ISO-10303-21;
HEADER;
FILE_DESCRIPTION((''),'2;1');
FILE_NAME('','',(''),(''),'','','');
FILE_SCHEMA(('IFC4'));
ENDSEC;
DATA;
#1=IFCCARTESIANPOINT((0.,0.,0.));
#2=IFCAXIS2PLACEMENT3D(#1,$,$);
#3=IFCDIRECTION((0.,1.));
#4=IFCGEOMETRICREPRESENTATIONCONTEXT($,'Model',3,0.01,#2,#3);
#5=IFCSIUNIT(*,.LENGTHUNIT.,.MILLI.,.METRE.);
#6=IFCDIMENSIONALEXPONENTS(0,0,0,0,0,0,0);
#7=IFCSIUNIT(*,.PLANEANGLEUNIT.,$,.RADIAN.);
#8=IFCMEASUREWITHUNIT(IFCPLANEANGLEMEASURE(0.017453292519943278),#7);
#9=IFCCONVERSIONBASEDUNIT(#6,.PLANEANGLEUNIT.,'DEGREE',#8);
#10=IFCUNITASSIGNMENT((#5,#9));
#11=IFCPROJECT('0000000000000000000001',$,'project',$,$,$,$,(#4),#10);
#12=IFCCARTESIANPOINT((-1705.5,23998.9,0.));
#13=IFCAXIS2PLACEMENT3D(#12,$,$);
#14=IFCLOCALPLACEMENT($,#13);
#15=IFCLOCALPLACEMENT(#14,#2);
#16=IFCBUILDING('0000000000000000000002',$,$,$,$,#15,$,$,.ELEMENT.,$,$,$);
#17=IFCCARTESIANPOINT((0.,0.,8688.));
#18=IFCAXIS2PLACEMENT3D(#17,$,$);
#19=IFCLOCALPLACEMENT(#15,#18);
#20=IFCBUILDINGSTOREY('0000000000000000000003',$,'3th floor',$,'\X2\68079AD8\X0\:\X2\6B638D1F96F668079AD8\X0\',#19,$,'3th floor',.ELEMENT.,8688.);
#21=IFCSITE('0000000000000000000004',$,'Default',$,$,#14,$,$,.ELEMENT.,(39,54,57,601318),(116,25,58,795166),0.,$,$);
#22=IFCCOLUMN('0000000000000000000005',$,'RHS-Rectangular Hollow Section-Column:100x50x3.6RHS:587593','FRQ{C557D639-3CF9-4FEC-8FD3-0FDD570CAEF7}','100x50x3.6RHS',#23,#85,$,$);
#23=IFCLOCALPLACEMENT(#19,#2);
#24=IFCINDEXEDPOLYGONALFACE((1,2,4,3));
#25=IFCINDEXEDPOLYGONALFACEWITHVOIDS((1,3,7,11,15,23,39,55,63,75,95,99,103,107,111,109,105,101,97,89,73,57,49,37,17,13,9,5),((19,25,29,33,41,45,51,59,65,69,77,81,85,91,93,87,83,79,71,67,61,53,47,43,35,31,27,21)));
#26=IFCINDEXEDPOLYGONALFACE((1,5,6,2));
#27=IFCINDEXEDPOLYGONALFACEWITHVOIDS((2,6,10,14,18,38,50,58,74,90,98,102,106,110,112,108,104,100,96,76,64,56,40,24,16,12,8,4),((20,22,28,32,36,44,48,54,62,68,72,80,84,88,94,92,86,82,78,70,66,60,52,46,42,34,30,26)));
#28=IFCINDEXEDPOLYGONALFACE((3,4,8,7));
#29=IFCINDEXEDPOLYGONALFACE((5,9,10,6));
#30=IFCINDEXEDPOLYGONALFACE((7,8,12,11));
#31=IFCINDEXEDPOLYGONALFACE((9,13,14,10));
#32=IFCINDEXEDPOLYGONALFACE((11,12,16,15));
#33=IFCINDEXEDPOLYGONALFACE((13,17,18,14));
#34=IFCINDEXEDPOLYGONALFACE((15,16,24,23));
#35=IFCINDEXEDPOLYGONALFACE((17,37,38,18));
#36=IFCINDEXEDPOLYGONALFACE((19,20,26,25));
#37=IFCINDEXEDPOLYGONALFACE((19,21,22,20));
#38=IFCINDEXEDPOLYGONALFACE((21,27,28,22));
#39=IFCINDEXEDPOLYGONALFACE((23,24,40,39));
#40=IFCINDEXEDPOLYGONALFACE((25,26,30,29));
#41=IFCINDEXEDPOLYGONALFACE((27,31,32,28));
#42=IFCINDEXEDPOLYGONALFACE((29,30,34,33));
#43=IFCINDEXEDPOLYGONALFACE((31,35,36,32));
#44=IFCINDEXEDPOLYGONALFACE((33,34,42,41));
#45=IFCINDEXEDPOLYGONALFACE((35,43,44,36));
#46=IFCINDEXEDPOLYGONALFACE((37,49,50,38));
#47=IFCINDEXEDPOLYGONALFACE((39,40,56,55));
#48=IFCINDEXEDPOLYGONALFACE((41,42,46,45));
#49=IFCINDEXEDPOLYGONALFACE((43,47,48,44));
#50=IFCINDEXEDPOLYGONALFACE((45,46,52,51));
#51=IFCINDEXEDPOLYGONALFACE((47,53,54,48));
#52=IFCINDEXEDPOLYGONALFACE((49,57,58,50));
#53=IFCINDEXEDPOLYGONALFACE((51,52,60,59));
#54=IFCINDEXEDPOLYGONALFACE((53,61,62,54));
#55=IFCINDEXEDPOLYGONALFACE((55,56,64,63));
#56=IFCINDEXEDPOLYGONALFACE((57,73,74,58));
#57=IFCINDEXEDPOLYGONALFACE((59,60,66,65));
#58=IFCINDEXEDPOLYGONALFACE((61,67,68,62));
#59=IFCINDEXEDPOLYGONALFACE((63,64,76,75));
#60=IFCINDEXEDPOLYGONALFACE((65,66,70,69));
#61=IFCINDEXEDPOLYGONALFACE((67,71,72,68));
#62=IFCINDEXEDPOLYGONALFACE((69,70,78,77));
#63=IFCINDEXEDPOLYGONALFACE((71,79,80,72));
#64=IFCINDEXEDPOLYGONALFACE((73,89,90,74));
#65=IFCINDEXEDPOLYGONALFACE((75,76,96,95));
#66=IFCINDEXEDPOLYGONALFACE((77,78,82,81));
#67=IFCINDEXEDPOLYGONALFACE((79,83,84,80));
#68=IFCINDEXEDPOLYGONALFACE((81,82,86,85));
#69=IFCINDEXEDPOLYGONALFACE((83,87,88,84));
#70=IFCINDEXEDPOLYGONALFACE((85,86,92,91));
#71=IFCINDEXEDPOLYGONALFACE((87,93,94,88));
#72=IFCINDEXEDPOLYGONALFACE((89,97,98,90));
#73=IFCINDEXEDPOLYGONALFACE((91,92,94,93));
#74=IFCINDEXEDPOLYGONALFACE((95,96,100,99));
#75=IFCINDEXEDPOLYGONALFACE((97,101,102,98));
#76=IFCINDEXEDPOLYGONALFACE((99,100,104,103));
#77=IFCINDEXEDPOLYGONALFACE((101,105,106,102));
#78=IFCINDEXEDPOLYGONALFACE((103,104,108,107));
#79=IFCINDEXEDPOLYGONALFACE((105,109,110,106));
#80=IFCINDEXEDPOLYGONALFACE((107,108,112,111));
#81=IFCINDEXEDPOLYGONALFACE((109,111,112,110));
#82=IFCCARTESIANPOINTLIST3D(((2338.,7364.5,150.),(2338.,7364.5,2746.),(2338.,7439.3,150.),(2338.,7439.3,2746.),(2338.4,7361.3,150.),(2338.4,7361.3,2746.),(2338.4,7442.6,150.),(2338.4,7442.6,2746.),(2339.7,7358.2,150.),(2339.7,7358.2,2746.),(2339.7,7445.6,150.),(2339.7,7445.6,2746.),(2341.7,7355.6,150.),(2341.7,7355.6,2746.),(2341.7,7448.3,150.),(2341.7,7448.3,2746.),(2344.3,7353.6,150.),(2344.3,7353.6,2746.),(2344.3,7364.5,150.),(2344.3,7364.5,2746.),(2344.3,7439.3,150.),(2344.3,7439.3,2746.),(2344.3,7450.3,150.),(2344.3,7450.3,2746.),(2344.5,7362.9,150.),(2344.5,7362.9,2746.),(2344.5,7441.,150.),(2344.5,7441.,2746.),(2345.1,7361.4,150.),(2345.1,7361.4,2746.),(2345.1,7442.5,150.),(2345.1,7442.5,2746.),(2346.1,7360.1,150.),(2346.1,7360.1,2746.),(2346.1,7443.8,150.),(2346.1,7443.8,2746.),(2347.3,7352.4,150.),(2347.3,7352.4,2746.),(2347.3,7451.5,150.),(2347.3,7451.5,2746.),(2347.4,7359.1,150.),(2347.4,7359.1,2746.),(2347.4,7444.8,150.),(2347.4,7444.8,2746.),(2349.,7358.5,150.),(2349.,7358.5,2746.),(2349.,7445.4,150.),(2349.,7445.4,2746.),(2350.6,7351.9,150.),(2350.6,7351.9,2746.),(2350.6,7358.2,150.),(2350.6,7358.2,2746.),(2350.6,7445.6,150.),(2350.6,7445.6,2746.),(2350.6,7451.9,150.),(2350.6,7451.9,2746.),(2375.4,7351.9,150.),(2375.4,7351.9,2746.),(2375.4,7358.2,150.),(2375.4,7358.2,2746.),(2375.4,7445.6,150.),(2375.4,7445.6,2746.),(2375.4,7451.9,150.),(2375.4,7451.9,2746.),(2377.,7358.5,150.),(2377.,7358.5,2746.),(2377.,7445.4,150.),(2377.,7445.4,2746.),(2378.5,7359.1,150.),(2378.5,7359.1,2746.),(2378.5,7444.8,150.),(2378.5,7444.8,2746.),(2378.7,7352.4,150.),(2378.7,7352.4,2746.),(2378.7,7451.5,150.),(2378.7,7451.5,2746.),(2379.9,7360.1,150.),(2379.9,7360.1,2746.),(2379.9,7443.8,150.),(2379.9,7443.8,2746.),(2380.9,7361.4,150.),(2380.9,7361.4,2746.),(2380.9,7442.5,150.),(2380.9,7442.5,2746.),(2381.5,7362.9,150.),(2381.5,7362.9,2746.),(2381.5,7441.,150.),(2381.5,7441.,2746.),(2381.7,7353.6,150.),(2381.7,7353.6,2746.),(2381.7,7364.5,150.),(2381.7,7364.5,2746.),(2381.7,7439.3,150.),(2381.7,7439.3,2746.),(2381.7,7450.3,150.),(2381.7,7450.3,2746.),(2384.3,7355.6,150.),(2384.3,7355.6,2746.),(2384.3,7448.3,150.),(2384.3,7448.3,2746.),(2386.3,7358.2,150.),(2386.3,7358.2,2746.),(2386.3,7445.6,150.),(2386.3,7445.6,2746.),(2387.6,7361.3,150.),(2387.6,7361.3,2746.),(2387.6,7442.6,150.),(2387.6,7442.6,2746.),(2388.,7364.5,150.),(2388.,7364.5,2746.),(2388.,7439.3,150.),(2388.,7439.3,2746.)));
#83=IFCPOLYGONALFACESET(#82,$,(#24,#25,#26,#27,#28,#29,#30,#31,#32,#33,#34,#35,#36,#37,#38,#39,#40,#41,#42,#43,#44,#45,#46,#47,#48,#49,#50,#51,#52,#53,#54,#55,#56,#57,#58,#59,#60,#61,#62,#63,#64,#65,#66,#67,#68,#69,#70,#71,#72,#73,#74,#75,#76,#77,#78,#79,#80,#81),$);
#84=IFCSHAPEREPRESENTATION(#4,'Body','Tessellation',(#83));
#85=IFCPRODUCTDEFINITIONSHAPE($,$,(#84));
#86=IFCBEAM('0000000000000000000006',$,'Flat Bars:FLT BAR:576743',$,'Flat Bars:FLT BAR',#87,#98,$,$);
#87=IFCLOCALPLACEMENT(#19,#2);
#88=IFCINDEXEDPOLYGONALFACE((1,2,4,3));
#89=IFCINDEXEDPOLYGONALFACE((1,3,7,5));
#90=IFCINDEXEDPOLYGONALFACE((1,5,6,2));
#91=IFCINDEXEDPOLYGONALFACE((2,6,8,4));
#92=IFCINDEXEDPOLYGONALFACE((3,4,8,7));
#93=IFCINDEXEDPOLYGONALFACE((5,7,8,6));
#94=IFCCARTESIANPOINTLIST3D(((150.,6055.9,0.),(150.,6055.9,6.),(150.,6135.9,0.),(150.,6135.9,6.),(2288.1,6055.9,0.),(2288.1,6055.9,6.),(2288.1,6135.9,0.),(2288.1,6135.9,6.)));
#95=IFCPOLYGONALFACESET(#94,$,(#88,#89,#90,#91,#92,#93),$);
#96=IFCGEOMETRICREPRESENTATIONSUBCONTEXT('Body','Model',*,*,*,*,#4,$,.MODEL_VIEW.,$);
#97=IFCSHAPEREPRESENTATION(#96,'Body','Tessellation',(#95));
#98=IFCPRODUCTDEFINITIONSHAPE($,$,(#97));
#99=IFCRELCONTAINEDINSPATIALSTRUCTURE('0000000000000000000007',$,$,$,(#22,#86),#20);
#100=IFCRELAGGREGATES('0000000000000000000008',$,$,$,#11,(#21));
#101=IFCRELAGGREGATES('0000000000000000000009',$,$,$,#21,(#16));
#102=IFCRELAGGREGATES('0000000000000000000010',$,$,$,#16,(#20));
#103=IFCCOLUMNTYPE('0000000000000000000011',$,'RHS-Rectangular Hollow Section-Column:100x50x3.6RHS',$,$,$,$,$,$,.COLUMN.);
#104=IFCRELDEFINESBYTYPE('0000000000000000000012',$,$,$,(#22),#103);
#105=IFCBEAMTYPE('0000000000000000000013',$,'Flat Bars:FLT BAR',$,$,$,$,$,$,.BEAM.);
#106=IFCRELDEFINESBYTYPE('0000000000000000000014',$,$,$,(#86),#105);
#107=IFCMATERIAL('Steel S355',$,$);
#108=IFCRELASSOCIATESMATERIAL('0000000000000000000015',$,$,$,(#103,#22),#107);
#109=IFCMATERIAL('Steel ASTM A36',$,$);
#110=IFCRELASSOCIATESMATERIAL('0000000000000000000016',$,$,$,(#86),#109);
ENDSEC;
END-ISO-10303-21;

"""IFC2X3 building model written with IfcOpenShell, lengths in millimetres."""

from ifc_helpers import new_model, entity, si_unit, converted_unit, direction, frame, origin, origin_2d, origin_2d_with_axis, place, context, subcontext, project, spatial, rectangle, hollow_rectangle, extrude, clip, halfspace, material, type_object, element, save


model = new_model("IFC2X3")

# Units and contexts
model_context = context("Model", 3, precision=0.01, world=origin(), true_north=direction((0.0, 1.0)))
body_context = subcontext(model_context, "Body", "Model", "MODEL_VIEW")
ifc_project = project(units=[si_unit("LENGTHUNIT", "METRE", prefix="MILLI"), converted_unit("PLANEANGLEUNIT", "DEGREE", entity("IfcPlaneAngleMeasure", 0.017453292519943278), si_unit("PLANEANGLEUNIT", "RADIAN"), dimensions=[0, 0, 0, 0, 0, 0, 0])], contexts=[model_context])

# Site, building, storey
site_placement = place(None, frame((-1705.5, 23998.9, 0.0)))
site = spatial("IfcSite", under=ifc_project, at=site_placement, Name="Default", CompositionType="ELEMENT", RefLatitude=(39, 54, 57, 601318), RefLongitude=(116, 25, 58, 795166), RefElevation=0.0)
building_placement = place(site_placement, origin())
building = spatial("IfcBuilding", under=site, at=building_placement, CompositionType="ELEMENT")
storey_placement = place(building_placement, frame((0.0, 0.0, 8688.0)))
storey = spatial("IfcBuildingStorey", under=building, at=storey_placement, Name="3th floor", ObjectType="标高:正负零标高", LongName="3th floor", CompositionType="ELEMENT", Elevation=8688.0)

# Column
ifc_material_1 = material(Name="Steel S355")
column_type_1 = type_object("IfcColumnType", Name="RHS-Rectangular Hollow Section-Column:100x50x3.6RHS", PredefinedType="COLUMN", material=ifc_material_1)
column_1_placement = place(storey_placement, frame((2363.0, 7401.9, 2746.0)))
element("IfcColumn", 1, at=column_1_placement, inside=storey, type_object=column_type_1, material=ifc_material_1, Name="RHS-Rectangular Hollow Section-Column:100x50x3.6RHS:587593", Description="FRQ{C557D639-3CF9-4FEC-8FD3-0FDD570CAEF7}", ObjectType="100x50x3.6RHS", context=model_context, shape_type="Clipping", body=[
    clip(extrude(hollow_rectangle(XDim=50.0, YDim=100.0, WallThickness=6.3, InnerFilletRadius=6.3, OuterFilletRadius=12.6, at=origin_2d()), origin(), (0.0, 0.0, -1.0), 2651.9), halfspace(frame((-2363.0, -7401.9, -2596.0), z_axis=(0.0, 0.0, 1.0), x_axis=(1.0, 0.0, 0.0)), True)),
])

# Beam
ifc_material_2 = material(Name="Steel ASTM A36")
beam_type = type_object("IfcBeamType", Name="Flat Bars:FLT BAR", PredefinedType="BEAM")
beam_placement = place(storey_placement, frame((150.0, 6095.9, 6.0)))
element("IfcBeam", 2, at=beam_placement, inside=storey, type_object=beam_type, material=ifc_material_2, Name="Flat Bars:FLT BAR:576743", ObjectType="Flat Bars:FLT BAR", context=body_context, shape_type="SweptSolid", body=[
    extrude(rectangle(XDim=6.0, YDim=80.0, at=origin_2d_with_axis()), frame((0.0, 0.0, -3.0), z_axis=(1.0, 0.0, 0.0), x_axis=(0.0, 0.0, -1.0)), (0.0, 0.0, 1.0), 2138.1),
])

save(model, "model.ifc")
